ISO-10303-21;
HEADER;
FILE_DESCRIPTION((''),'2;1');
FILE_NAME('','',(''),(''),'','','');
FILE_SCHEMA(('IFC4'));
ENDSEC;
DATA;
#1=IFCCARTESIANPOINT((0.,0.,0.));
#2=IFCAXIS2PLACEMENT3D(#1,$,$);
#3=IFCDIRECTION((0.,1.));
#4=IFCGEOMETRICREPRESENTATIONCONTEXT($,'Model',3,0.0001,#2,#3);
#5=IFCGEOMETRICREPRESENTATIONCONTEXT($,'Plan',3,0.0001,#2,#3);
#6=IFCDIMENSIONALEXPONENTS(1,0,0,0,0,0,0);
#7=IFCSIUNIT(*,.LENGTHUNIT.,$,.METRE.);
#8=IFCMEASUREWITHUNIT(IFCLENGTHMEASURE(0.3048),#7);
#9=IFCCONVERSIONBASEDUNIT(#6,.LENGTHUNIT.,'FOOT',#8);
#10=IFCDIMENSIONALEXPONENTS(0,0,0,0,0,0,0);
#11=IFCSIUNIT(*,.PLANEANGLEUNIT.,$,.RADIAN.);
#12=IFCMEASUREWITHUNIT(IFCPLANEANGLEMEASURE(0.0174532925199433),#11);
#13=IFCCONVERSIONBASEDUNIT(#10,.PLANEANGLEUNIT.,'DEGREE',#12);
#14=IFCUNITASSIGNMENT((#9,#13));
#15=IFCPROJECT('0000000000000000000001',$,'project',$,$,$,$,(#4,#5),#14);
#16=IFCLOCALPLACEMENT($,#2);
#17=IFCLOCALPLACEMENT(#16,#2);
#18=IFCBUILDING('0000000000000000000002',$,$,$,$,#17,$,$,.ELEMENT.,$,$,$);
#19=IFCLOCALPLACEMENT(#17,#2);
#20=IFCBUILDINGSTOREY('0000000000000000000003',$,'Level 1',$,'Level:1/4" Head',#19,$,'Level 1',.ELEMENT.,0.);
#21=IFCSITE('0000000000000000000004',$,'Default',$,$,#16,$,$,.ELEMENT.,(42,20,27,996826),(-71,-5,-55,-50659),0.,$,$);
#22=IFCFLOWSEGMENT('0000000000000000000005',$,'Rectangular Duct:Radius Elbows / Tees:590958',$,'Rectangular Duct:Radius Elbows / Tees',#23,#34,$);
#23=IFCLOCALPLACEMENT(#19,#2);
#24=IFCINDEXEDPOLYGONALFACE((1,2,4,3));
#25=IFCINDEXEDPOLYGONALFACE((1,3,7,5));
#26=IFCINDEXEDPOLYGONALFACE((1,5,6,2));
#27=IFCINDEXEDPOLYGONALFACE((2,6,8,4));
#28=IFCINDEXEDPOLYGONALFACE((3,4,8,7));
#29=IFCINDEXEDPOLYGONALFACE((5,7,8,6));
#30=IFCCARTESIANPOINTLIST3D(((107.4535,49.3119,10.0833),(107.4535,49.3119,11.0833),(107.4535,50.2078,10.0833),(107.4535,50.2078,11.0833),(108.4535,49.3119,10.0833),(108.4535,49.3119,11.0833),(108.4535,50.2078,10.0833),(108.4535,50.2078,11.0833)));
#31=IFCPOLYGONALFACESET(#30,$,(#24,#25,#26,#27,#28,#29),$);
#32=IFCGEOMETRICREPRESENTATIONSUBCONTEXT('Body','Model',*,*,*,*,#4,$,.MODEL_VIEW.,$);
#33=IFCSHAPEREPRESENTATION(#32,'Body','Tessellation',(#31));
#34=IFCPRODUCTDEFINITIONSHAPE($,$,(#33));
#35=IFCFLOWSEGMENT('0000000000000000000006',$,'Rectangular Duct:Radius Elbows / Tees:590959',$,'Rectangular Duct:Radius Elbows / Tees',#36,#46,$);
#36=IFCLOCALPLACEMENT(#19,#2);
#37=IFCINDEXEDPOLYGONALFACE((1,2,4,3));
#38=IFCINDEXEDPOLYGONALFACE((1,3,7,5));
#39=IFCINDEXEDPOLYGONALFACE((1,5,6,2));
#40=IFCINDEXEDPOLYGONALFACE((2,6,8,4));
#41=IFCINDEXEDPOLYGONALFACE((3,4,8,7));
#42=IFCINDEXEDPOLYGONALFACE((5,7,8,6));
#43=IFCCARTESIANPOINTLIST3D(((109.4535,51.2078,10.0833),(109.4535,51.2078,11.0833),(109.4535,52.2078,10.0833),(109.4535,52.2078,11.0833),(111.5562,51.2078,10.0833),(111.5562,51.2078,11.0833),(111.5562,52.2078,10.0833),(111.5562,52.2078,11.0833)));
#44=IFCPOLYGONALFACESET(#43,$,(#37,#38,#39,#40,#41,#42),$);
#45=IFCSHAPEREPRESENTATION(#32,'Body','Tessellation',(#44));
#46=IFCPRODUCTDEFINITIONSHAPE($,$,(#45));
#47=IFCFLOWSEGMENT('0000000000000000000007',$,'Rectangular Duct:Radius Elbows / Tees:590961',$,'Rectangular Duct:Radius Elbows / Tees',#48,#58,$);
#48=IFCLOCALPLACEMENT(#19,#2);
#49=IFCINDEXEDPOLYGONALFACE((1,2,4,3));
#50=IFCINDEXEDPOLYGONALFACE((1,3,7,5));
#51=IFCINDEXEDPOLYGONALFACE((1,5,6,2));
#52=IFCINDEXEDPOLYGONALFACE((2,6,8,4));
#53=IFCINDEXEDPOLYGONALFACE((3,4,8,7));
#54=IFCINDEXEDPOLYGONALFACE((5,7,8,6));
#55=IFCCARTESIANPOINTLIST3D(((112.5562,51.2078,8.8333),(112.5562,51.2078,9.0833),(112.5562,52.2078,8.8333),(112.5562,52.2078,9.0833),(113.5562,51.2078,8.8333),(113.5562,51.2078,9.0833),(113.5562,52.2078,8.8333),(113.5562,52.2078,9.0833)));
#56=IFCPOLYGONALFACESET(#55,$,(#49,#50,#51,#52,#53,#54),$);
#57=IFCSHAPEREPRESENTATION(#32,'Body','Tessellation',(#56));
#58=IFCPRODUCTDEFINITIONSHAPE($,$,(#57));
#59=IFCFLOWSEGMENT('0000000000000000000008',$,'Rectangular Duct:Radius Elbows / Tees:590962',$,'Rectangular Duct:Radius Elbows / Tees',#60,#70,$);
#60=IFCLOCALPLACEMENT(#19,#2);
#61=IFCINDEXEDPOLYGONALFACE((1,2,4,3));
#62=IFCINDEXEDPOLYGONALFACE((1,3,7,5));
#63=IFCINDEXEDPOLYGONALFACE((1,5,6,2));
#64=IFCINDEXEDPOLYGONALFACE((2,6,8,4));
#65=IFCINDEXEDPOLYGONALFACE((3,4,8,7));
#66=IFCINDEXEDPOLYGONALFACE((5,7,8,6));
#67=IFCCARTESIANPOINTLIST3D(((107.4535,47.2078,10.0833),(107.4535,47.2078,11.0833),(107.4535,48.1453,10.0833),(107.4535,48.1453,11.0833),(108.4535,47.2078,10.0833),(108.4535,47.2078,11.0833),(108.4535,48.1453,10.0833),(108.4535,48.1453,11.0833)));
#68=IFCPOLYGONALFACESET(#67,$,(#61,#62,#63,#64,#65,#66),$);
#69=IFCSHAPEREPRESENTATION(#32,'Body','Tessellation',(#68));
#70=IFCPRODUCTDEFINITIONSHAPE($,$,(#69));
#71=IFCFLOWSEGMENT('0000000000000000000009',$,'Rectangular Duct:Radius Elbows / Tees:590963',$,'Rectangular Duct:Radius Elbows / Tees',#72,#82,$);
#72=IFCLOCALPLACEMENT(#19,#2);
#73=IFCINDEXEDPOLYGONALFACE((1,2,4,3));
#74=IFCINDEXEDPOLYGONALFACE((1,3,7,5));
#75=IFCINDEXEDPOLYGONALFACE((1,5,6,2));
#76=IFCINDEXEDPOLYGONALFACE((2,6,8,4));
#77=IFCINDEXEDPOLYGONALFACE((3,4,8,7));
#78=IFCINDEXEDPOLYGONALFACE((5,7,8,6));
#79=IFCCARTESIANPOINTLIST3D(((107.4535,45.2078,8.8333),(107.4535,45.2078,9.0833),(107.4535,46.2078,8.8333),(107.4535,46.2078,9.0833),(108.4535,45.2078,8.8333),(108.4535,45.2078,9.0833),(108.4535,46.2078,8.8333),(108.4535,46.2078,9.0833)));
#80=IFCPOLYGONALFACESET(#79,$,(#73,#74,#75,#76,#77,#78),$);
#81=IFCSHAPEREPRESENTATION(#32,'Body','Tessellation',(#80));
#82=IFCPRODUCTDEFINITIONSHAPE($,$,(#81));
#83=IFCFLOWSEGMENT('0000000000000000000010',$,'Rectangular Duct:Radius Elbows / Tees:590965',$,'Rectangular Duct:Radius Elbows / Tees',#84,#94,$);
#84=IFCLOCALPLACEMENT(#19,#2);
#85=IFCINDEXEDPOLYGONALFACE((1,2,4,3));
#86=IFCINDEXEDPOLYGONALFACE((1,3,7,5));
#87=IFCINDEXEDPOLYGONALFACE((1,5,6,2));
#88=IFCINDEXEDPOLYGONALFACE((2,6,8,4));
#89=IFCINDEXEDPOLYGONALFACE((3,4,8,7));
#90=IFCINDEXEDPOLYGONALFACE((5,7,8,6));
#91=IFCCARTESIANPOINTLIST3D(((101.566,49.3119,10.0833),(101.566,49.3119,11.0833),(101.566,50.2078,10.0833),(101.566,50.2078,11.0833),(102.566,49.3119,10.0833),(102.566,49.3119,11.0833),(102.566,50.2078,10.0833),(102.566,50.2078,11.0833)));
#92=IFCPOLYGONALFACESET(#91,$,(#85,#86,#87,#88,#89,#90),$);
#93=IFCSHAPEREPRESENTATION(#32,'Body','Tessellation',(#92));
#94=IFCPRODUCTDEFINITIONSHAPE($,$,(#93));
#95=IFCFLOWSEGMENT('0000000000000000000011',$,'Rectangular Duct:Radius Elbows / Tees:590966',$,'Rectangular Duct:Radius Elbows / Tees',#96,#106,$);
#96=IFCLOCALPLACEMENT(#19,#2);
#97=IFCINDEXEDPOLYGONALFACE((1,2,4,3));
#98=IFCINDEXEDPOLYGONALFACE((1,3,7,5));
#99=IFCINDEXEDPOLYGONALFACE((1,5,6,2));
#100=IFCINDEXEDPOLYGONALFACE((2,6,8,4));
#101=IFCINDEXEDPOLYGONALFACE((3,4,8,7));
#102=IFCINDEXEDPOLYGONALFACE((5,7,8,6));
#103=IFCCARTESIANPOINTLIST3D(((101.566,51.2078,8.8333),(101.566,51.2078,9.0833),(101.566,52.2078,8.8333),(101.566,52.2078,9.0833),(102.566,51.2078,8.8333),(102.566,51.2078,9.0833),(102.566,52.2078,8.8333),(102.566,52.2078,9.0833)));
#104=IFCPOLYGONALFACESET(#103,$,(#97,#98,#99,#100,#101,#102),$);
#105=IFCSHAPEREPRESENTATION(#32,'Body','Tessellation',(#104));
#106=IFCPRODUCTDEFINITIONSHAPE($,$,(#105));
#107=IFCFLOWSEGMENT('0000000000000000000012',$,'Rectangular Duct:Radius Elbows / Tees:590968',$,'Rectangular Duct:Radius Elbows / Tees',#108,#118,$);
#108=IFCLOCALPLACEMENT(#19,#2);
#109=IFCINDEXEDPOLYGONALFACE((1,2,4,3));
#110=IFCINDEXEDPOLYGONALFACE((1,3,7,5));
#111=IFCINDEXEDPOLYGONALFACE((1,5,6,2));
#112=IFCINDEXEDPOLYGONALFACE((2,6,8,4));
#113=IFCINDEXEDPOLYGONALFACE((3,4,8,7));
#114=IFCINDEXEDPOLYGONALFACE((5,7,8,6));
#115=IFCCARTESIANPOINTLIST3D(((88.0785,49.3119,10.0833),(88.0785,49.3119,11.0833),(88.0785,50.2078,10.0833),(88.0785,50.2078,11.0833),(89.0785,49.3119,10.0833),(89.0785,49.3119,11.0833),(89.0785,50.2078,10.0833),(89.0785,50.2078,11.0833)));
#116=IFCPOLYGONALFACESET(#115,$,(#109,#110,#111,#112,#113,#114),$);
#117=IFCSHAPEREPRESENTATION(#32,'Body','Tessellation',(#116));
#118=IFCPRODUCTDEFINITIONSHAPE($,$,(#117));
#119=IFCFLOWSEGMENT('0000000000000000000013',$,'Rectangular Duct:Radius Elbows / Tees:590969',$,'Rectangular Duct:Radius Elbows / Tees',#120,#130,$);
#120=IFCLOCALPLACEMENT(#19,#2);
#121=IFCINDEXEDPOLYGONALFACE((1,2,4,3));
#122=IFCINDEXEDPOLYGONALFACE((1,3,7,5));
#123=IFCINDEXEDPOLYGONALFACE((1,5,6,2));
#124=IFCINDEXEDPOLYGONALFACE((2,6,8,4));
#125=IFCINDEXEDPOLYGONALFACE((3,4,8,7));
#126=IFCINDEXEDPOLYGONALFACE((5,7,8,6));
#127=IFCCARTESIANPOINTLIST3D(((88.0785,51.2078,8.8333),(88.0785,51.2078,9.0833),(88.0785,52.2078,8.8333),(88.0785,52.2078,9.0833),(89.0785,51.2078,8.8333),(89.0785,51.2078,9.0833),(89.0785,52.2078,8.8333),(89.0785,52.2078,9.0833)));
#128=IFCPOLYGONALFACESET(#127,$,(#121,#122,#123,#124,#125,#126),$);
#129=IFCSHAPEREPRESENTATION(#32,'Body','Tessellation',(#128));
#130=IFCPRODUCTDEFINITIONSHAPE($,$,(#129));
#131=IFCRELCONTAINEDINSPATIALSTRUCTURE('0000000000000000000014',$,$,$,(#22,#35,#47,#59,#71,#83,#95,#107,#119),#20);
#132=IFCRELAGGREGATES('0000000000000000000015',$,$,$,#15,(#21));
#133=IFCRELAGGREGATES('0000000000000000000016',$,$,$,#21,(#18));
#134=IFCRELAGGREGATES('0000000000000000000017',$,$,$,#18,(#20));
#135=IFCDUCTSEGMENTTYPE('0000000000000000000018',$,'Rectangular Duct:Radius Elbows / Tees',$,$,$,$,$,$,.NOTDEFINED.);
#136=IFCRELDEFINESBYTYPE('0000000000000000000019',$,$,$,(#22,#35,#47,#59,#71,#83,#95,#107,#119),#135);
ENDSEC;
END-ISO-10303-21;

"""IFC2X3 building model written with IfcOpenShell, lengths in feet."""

from ifc_helpers import new_model, entity, si_unit, converted_unit, direction, frame, frame_2d, origin, origin_2d_with_axis, place, context, subcontext, project, spatial, rectangle, extrude, type_object, element, save


model = new_model("IFC2X3")

# Units and contexts
model_context = context("Model", 3, precision=0.0001, world=origin(), true_north=direction((0.0, 1.0)))
plan_context = context("Plan", 3, precision=0.0001, world=origin(), true_north=direction((0.0, 1.0)))
body_context = subcontext(model_context, "Body", "Model", "MODEL_VIEW")
ifc_project = project(units=[converted_unit("LENGTHUNIT", "FOOT", entity("IfcLengthMeasure", 0.3048), si_unit("LENGTHUNIT", "METRE"), dimensions=[1, 0, 0, 0, 0, 0, 0]), converted_unit("PLANEANGLEUNIT", "DEGREE", entity("IfcPlaneAngleMeasure", 0.0174532925199433), si_unit("PLANEANGLEUNIT", "RADIAN"), dimensions=[0, 0, 0, 0, 0, 0, 0])], contexts=[model_context, plan_context])

# Site, building, storey
site_placement = place(None, origin())
site = spatial("IfcSite", under=ifc_project, at=site_placement, Name="Default", CompositionType="ELEMENT", RefLatitude=(42, 20, 27, 996826), RefLongitude=(-71, -5, -55, -50659), RefElevation=0.0)
building_placement = place(site_placement, origin())
building = spatial("IfcBuilding", under=site, at=building_placement, CompositionType="ELEMENT")
storey_placement = place(building_placement, origin())
storey = spatial("IfcBuildingStorey", under=building, at=storey_placement, Name="Level 1", ObjectType="Level:1/4\" Head", LongName="Level 1", CompositionType="ELEMENT", Elevation=0.0)

# Flow segments
duct_segment_type = type_object("IfcDuctSegmentType", Name="Rectangular Duct:Radius Elbows / Tees", PredefinedType="NOTDEFINED")
flow_segment_1_placement = place(storey_placement, origin())
element("IfcFlowSegment", 1, at=flow_segment_1_placement, inside=storey, type_object=duct_segment_type, Name="Rectangular Duct:Radius Elbows / Tees:590958", ObjectType="Rectangular Duct:Radius Elbows / Tees", context=body_context, shape_type="SweptSolid", body=[
    extrude(rectangle(XDim=0.8958, YDim=1.0, at=frame_2d((0.0, 0.0), x_axis=(1.0, 0.0))), frame((107.9535, 49.7599, 10.0833), z_axis=(0.0, 0.0, 1.0), x_axis=(0.0, 1.0, 0.0)), (0.0, 0.0, 1.0), 1.0),
])
flow_segment_2_placement = place(storey_placement, origin())
element("IfcFlowSegment", 2, at=flow_segment_2_placement, inside=storey, type_object=duct_segment_type, Name="Rectangular Duct:Radius Elbows / Tees:590959", ObjectType="Rectangular Duct:Radius Elbows / Tees", context=body_context, shape_type="SweptSolid", body=[
    extrude(rectangle(XDim=2.1027, YDim=1.0, at=frame_2d((0.0, 0.0), x_axis=(1.0, 0.0))), frame((110.5049, 51.7078, 10.0833), z_axis=(0.0, 0.0, 1.0), x_axis=(-1.0, 0.0, 0.0)), (0.0, 0.0, 1.0), 1.0),
])
flow_segment_3_placement = place(storey_placement, origin())
element("IfcFlowSegment", 3, at=flow_segment_3_placement, inside=storey, type_object=duct_segment_type, Name="Rectangular Duct:Radius Elbows / Tees:590961", ObjectType="Rectangular Duct:Radius Elbows / Tees", context=body_context, shape_type="SweptSolid", body=[
    extrude(rectangle(XDim=1.0, YDim=1.0, at=origin_2d_with_axis()), frame((113.0562, 51.7078, 8.8333), z_axis=(0.0, 0.0, 1.0), x_axis=(0.0, 1.0, 0.0)), (0.0, 0.0, 1.0), 0.25),
])
flow_segment_4_placement = place(storey_placement, origin())
element("IfcFlowSegment", 4, at=flow_segment_4_placement, inside=storey, type_object=duct_segment_type, Name="Rectangular Duct:Radius Elbows / Tees:590962", ObjectType="Rectangular Duct:Radius Elbows / Tees", context=body_context, shape_type="SweptSolid", body=[
    extrude(rectangle(XDim=0.9375, YDim=1.0, at=frame_2d((0.0, 0.0), x_axis=(1.0, 0.0))), frame((107.9535, 47.6765, 10.0833), z_axis=(0.0, 0.0, 1.0), x_axis=(0.0, 1.0, 0.0)), (0.0, 0.0, 1.0), 1.0),
])
flow_segment_5_placement = place(storey_placement, origin())
element("IfcFlowSegment", 5, at=flow_segment_5_placement, inside=storey, type_object=duct_segment_type, Name="Rectangular Duct:Radius Elbows / Tees:590963", ObjectType="Rectangular Duct:Radius Elbows / Tees", context=body_context, shape_type="SweptSolid", body=[
    extrude(rectangle(XDim=1.0, YDim=1.0, at=origin_2d_with_axis()), frame((107.9535, 45.7078, 8.8333), z_axis=(0.0, 0.0, 1.0), x_axis=(0.0, 1.0, 0.0)), (0.0, 0.0, 1.0), 0.25),
])
flow_segment_6_placement = place(storey_placement, origin())
element("IfcFlowSegment", 6, at=flow_segment_6_placement, inside=storey, type_object=duct_segment_type, Name="Rectangular Duct:Radius Elbows / Tees:590965", ObjectType="Rectangular Duct:Radius Elbows / Tees", context=body_context, shape_type="SweptSolid", body=[
    extrude(rectangle(XDim=0.8958, YDim=1.0, at=frame_2d((0.0, 0.0), x_axis=(1.0, 0.0))), frame((102.066, 49.7599, 10.0833), z_axis=(0.0, 0.0, 1.0), x_axis=(0.0, 1.0, 0.0)), (0.0, 0.0, 1.0), 1.0),
])
flow_segment_7_placement = place(storey_placement, origin())
element("IfcFlowSegment", 7, at=flow_segment_7_placement, inside=storey, type_object=duct_segment_type, Name="Rectangular Duct:Radius Elbows / Tees:590966", ObjectType="Rectangular Duct:Radius Elbows / Tees", context=body_context, shape_type="SweptSolid", body=[
    extrude(rectangle(XDim=1.0, YDim=1.0, at=origin_2d_with_axis()), frame((102.066, 51.7078, 8.8333), z_axis=(0.0, 0.0, 1.0), x_axis=(0.0, 1.0, 0.0)), (0.0, 0.0, 1.0), 0.25),
])
flow_segment_8_placement = place(storey_placement, origin())
element("IfcFlowSegment", 8, at=flow_segment_8_placement, inside=storey, type_object=duct_segment_type, Name="Rectangular Duct:Radius Elbows / Tees:590968", ObjectType="Rectangular Duct:Radius Elbows / Tees", context=body_context, shape_type="SweptSolid", body=[
    extrude(rectangle(XDim=0.8958, YDim=1.0, at=frame_2d((0.0, 0.0), x_axis=(1.0, 0.0))), frame((88.5785, 49.7599, 10.0833), z_axis=(0.0, 0.0, 1.0), x_axis=(0.0, 1.0, 0.0)), (0.0, 0.0, 1.0), 1.0),
])
flow_segment_9_placement = place(storey_placement, origin())
element("IfcFlowSegment", 9, at=flow_segment_9_placement, inside=storey, type_object=duct_segment_type, Name="Rectangular Duct:Radius Elbows / Tees:590969", ObjectType="Rectangular Duct:Radius Elbows / Tees", context=body_context, shape_type="SweptSolid", body=[
    extrude(rectangle(XDim=1.0, YDim=1.0, at=origin_2d_with_axis()), frame((88.5785, 51.7078, 8.8333), z_axis=(0.0, 0.0, 1.0), x_axis=(0.0, 1.0, 0.0)), (0.0, 0.0, 1.0), 0.25),
])

save(model, "model.ifc")
